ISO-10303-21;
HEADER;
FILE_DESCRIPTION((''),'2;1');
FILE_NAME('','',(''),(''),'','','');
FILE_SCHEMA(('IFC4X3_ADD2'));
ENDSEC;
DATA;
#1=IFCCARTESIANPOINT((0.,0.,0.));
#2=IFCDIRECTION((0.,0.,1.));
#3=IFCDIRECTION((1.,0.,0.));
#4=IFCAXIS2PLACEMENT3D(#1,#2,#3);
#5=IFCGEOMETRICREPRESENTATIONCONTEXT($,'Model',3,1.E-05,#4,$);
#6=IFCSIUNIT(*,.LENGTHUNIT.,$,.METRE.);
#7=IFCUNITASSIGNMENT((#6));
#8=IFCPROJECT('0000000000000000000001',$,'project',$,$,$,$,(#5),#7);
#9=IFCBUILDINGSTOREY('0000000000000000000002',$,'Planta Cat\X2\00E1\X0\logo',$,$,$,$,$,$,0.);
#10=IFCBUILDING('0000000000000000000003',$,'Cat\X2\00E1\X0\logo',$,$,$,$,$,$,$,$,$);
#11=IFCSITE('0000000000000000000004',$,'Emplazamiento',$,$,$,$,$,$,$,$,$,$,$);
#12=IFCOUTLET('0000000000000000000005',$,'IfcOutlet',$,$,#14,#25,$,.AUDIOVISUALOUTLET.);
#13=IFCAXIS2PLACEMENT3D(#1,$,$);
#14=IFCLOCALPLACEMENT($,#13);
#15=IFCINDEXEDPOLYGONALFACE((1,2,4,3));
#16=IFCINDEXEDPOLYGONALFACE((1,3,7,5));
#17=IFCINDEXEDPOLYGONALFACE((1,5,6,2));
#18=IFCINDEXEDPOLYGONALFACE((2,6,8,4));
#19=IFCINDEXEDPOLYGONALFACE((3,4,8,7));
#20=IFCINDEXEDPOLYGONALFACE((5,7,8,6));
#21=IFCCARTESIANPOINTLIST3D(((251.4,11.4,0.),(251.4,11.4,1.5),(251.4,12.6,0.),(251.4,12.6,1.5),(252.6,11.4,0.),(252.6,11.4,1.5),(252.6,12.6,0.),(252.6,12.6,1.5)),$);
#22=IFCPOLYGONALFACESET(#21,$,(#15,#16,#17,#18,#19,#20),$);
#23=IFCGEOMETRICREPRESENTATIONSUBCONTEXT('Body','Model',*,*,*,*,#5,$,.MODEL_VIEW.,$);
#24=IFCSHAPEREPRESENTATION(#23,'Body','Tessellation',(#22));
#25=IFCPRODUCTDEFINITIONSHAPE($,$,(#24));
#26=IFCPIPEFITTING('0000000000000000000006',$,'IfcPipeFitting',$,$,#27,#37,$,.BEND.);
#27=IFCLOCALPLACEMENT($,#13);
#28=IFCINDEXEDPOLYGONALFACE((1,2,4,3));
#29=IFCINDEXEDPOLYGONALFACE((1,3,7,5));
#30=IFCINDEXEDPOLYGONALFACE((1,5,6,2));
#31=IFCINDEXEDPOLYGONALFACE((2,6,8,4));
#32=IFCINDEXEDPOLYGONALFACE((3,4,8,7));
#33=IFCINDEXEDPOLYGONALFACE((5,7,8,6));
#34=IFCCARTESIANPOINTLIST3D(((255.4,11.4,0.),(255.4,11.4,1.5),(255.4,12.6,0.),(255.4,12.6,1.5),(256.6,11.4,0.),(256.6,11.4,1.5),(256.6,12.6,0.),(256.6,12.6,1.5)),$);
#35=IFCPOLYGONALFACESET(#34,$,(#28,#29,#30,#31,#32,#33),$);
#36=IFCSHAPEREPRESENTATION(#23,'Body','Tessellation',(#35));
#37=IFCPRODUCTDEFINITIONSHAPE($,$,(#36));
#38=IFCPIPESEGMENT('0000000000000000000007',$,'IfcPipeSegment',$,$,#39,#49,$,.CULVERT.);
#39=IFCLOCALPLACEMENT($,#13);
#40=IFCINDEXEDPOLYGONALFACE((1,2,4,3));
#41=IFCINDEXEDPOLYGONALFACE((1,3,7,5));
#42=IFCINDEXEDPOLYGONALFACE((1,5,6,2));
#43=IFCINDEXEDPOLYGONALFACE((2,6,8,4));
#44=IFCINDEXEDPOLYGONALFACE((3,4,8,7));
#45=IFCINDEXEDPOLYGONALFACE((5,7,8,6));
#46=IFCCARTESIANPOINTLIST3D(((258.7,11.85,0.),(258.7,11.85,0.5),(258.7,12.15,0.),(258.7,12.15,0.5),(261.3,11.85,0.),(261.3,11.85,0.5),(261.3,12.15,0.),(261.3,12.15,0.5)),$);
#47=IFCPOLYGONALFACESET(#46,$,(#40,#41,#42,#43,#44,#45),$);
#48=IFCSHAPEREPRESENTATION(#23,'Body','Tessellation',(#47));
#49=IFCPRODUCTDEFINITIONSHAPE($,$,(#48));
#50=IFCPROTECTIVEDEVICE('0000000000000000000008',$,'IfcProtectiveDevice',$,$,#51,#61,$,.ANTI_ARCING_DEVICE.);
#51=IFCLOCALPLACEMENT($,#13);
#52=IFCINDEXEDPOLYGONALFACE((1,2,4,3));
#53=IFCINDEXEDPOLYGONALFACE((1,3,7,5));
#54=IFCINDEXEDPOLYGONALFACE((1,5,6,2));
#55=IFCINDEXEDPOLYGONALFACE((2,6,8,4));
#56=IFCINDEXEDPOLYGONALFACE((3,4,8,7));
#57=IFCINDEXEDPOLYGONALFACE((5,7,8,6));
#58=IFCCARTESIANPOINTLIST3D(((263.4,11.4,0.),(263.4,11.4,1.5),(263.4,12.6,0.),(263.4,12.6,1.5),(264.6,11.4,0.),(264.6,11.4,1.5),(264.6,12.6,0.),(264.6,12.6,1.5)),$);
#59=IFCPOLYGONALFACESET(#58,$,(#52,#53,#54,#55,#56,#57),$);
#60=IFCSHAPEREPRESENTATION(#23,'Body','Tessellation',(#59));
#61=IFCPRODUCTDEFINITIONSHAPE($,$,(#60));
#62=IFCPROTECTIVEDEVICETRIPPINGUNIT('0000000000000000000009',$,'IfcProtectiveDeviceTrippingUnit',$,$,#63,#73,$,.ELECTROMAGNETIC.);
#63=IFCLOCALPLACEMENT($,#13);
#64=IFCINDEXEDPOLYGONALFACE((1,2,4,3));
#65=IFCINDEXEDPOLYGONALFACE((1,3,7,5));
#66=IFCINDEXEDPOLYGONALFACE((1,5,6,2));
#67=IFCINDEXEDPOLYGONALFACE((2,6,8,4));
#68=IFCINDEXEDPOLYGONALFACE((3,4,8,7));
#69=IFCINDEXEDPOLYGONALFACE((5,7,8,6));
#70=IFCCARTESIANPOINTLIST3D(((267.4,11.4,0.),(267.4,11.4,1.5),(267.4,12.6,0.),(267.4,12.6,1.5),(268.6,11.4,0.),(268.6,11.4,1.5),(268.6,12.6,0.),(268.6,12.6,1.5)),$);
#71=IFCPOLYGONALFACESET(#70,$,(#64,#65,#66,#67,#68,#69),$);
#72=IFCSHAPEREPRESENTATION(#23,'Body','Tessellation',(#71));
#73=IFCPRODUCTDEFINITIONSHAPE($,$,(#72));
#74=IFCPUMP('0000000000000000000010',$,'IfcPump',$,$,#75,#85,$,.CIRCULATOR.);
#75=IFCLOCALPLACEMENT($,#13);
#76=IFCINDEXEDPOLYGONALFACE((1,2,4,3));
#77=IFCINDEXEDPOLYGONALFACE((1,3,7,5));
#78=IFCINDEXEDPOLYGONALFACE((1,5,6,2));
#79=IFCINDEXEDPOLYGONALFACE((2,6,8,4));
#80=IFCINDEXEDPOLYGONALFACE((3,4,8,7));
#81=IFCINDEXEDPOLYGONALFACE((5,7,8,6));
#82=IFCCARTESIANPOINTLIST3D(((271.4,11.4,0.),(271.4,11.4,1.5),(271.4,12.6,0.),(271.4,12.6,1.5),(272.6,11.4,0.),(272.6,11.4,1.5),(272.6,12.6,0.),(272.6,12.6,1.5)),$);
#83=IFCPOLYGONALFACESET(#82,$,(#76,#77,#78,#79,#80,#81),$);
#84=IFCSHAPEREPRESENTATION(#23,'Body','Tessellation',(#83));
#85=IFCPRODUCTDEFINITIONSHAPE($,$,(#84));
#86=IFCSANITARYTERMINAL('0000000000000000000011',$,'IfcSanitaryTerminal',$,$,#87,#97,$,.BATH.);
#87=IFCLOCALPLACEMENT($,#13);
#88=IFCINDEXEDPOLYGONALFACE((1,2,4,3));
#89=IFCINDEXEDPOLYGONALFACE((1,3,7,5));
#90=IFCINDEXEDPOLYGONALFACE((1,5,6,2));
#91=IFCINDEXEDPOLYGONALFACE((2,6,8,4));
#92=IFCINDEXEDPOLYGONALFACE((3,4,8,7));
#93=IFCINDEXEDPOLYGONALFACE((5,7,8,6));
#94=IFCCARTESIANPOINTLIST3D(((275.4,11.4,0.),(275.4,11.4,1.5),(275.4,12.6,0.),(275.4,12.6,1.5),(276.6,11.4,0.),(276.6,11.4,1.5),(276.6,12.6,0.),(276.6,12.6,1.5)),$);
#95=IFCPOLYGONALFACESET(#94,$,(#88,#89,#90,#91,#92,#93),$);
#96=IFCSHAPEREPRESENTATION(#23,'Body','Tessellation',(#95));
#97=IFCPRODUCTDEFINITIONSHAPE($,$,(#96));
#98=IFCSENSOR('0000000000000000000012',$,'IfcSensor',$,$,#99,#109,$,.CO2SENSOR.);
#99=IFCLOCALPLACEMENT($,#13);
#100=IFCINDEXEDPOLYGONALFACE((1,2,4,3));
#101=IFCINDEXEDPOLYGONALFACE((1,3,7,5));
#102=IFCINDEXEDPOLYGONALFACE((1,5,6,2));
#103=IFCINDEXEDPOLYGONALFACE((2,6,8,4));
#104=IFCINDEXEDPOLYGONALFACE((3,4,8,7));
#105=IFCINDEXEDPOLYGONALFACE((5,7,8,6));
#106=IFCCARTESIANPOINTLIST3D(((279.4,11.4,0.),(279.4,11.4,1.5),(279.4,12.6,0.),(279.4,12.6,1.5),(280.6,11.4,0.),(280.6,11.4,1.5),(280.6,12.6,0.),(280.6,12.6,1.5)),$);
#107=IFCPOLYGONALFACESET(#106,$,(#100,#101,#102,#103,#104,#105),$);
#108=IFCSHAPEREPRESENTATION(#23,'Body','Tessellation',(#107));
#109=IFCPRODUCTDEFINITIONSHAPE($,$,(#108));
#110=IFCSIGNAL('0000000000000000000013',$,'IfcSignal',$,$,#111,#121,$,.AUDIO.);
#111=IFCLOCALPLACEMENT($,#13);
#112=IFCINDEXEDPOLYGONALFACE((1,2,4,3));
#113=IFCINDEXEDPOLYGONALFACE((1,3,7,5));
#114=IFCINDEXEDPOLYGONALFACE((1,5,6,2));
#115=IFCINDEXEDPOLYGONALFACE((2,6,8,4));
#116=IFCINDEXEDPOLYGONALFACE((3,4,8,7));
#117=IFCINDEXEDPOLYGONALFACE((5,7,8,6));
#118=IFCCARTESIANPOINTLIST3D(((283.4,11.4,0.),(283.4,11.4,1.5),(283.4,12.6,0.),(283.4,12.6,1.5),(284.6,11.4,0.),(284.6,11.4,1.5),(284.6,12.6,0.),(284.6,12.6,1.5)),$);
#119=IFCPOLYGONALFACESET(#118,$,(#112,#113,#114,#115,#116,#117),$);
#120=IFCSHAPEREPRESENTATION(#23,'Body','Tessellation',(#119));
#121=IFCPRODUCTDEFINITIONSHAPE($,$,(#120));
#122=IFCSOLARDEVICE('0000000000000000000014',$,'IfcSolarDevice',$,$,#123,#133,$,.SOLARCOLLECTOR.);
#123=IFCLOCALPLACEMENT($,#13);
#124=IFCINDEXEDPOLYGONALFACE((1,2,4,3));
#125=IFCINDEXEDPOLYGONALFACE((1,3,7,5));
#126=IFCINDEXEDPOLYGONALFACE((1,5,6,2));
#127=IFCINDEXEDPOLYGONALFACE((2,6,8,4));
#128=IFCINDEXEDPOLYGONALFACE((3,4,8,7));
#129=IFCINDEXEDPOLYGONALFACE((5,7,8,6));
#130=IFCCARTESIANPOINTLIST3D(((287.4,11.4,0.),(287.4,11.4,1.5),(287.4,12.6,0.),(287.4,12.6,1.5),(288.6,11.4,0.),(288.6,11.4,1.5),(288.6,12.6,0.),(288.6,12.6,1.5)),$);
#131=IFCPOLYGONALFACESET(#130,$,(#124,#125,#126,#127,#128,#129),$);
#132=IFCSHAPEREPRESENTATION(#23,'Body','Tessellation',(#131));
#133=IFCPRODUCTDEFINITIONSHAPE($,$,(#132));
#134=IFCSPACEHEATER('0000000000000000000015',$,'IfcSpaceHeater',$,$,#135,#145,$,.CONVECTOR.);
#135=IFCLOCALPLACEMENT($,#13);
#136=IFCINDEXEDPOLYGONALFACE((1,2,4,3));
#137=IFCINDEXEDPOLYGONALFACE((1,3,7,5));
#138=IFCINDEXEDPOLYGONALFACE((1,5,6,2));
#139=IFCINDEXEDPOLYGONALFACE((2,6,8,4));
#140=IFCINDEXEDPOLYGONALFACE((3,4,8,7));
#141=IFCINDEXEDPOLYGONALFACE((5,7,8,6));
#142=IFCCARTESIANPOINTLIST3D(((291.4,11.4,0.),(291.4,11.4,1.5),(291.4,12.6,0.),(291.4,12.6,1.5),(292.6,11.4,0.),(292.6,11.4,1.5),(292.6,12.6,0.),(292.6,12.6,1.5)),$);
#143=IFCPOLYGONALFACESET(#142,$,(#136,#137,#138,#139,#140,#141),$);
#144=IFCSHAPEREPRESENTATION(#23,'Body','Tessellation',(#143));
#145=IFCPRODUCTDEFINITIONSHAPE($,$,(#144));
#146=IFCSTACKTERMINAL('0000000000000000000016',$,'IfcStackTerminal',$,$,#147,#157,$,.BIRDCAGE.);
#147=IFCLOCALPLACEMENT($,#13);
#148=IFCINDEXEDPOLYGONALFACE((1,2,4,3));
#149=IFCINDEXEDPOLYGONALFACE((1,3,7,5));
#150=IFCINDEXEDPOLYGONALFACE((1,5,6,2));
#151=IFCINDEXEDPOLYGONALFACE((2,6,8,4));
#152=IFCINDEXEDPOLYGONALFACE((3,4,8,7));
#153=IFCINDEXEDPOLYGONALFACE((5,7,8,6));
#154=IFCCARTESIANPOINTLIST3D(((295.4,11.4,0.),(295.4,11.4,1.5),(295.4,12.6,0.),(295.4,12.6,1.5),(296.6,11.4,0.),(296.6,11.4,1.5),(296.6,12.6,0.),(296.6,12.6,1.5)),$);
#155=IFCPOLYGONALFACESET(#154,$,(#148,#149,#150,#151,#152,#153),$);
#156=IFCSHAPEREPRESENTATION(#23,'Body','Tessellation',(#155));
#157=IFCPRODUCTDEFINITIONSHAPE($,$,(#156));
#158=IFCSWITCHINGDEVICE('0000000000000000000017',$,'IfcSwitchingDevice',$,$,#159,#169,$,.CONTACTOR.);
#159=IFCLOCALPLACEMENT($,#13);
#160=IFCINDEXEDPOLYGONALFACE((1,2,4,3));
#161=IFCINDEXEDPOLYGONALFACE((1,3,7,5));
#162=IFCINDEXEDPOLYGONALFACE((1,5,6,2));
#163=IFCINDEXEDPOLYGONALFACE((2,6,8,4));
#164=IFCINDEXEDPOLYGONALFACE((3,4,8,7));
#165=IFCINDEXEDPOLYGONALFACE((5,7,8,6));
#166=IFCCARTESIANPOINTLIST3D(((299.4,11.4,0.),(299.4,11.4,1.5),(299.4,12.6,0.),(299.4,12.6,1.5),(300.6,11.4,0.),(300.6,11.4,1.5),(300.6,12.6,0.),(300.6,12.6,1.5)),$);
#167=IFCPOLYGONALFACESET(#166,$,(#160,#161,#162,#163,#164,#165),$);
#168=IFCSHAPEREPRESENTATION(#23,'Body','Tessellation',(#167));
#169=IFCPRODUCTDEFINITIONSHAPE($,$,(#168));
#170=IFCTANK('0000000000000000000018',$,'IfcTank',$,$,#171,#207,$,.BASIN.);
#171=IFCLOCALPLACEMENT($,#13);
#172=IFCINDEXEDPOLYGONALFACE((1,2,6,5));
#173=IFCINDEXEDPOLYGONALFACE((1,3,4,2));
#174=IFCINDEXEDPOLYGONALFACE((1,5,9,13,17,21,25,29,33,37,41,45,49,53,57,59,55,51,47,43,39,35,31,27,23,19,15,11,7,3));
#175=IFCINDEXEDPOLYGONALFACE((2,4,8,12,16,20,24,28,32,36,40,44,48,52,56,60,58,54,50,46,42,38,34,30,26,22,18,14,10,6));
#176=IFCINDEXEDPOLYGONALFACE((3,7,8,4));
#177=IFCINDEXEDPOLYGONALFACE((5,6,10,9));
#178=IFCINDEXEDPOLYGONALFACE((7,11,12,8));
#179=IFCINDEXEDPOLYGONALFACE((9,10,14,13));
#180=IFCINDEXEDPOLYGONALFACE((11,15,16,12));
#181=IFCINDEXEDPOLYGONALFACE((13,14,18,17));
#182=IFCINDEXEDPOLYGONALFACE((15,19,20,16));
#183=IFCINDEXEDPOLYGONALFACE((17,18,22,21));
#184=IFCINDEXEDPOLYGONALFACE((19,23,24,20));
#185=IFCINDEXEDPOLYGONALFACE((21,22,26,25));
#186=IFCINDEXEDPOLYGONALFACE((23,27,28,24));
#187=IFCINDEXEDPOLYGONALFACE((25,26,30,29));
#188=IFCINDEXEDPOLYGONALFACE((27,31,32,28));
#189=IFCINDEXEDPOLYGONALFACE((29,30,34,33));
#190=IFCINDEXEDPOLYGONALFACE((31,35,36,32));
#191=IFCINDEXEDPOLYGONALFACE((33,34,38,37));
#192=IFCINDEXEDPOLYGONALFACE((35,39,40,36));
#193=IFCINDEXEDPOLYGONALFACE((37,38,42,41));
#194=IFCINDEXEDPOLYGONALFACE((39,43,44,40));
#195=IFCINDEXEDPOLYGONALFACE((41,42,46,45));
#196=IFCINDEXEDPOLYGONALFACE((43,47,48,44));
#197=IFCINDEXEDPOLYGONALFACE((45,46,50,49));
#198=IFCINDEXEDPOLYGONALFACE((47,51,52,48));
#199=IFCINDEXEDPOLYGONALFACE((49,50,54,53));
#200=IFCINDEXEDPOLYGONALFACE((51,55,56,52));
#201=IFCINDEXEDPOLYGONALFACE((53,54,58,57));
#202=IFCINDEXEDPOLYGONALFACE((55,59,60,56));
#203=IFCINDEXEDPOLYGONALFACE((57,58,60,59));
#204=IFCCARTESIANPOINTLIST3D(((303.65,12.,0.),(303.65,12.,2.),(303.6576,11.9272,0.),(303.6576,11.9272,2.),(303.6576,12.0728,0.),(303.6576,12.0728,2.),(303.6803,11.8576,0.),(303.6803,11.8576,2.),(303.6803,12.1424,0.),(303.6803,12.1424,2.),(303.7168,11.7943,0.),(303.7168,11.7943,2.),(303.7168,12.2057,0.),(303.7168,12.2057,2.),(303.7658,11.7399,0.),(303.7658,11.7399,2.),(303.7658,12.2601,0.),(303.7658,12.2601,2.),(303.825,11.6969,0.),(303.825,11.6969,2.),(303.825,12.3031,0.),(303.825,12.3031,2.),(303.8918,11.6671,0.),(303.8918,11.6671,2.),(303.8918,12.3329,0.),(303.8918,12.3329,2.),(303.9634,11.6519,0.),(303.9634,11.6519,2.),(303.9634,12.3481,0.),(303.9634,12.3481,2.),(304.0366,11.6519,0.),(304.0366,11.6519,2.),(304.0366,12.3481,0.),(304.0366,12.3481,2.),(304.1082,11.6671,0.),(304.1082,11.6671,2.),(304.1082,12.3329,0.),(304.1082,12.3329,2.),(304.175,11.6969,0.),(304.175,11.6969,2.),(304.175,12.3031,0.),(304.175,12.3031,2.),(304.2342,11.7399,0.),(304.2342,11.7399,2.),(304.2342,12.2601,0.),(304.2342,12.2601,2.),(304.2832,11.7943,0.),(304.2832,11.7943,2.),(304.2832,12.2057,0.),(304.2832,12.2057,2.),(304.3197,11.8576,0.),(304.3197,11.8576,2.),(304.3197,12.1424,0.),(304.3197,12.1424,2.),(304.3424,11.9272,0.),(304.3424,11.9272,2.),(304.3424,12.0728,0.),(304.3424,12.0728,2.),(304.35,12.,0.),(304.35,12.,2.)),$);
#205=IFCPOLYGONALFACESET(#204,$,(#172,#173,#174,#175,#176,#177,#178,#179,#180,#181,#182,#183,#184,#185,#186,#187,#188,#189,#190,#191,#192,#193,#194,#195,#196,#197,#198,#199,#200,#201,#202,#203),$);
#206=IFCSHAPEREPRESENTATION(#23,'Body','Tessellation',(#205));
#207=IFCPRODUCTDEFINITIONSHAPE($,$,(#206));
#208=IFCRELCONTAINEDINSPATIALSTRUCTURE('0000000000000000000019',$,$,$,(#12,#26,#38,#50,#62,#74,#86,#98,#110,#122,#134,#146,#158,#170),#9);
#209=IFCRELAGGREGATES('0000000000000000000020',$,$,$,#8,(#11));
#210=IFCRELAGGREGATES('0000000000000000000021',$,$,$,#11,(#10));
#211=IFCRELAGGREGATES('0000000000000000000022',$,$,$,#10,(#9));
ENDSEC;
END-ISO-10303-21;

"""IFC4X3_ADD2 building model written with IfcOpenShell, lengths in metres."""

from ifc_helpers import new_model, si_unit, frame, origin, origin_with_axes, origin_2d, place, context, subcontext, project, spatial, rectangle, circle, extrude, element, save


model = new_model("IFC4X3_ADD2")

# Units and contexts
model_context = context("Model", 3, precision=1e-05, world=origin_with_axes())
body_context = subcontext(model_context, "Body", "Model", "MODEL_VIEW")
ifc_project = project(units=[si_unit("LENGTHUNIT", "METRE")], contexts=[model_context])

# Site, building, storey
site = spatial("IfcSite", under=ifc_project, Name="Emplazamiento")
building = spatial("IfcBuilding", under=site, Name="Catálogo")
storey = spatial("IfcBuildingStorey", under=building, Name="Planta Catálogo", Elevation=0.0)

# Outlet
outlet_placement = place(None, frame((252.0, 12.0, 0.0), z_axis=(0.0, 0.0, 1.0), x_axis=(1.0, 0.0, 0.0)))
element("IfcOutlet", 1, at=outlet_placement, inside=storey, Name="IfcOutlet", PredefinedType="AUDIOVISUALOUTLET", context=body_context, shape_type="SweptSolid", body=[
    extrude(rectangle(XDim=1.2, YDim=1.2, at=origin_2d()), origin(), (0.0, 0.0, 1.0), 1.5),
])

# Pipe fitting
pipe_fitting_placement = place(None, frame((256.0, 12.0, 0.0), z_axis=(0.0, 0.0, 1.0), x_axis=(1.0, 0.0, 0.0)))
element("IfcPipeFitting", 2, at=pipe_fitting_placement, inside=storey, Name="IfcPipeFitting", PredefinedType="BEND", context=body_context, shape_type="SweptSolid", body=[
    extrude(rectangle(XDim=1.2, YDim=1.2, at=origin_2d()), origin(), (0.0, 0.0, 1.0), 1.5),
])

# Pipe segment
pipe_segment_placement = place(None, frame((260.0, 12.0, 0.0), z_axis=(0.0, 0.0, 1.0), x_axis=(1.0, 0.0, 0.0)))
element("IfcPipeSegment", 3, at=pipe_segment_placement, inside=storey, Name="IfcPipeSegment", PredefinedType="CULVERT", context=body_context, shape_type="SweptSolid", body=[
    extrude(rectangle(XDim=2.6, YDim=0.3, at=origin_2d()), origin(), (0.0, 0.0, 1.0), 0.5),
])

# Protective device
protective_device_placement = place(None, frame((264.0, 12.0, 0.0), z_axis=(0.0, 0.0, 1.0), x_axis=(1.0, 0.0, 0.0)))
element("IfcProtectiveDevice", 4, at=protective_device_placement, inside=storey, Name="IfcProtectiveDevice", PredefinedType="ANTI_ARCING_DEVICE", context=body_context, shape_type="SweptSolid", body=[
    extrude(rectangle(XDim=1.2, YDim=1.2, at=origin_2d()), origin(), (0.0, 0.0, 1.0), 1.5),
])

# Protective device tripping unit
protective_device_tripping_unit_placement = place(None, frame((268.0, 12.0, 0.0), z_axis=(0.0, 0.0, 1.0), x_axis=(1.0, 0.0, 0.0)))
element("IfcProtectiveDeviceTrippingUnit", 5, at=protective_device_tripping_unit_placement, inside=storey, Name="IfcProtectiveDeviceTrippingUnit", PredefinedType="ELECTROMAGNETIC", context=body_context, shape_type="SweptSolid", body=[
    extrude(rectangle(XDim=1.2, YDim=1.2, at=origin_2d()), origin(), (0.0, 0.0, 1.0), 1.5),
])

# Pump
pump_placement = place(None, frame((272.0, 12.0, 0.0), z_axis=(0.0, 0.0, 1.0), x_axis=(1.0, 0.0, 0.0)))
element("IfcPump", 6, at=pump_placement, inside=storey, Name="IfcPump", PredefinedType="CIRCULATOR", context=body_context, shape_type="SweptSolid", body=[
    extrude(rectangle(XDim=1.2, YDim=1.2, at=origin_2d()), origin(), (0.0, 0.0, 1.0), 1.5),
])

# Sanitary terminal
sanitary_terminal_placement = place(None, frame((276.0, 12.0, 0.0), z_axis=(0.0, 0.0, 1.0), x_axis=(1.0, 0.0, 0.0)))
element("IfcSanitaryTerminal", 7, at=sanitary_terminal_placement, inside=storey, Name="IfcSanitaryTerminal", PredefinedType="BATH", context=body_context, shape_type="SweptSolid", body=[
    extrude(rectangle(XDim=1.2, YDim=1.2, at=origin_2d()), origin(), (0.0, 0.0, 1.0), 1.5),
])

# Sensor
sensor_placement = place(None, frame((280.0, 12.0, 0.0), z_axis=(0.0, 0.0, 1.0), x_axis=(1.0, 0.0, 0.0)))
element("IfcSensor", 8, at=sensor_placement, inside=storey, Name="IfcSensor", PredefinedType="CO2SENSOR", context=body_context, shape_type="SweptSolid", body=[
    extrude(rectangle(XDim=1.2, YDim=1.2, at=origin_2d()), origin(), (0.0, 0.0, 1.0), 1.5),
])

# Signal
signal_placement = place(None, frame((284.0, 12.0, 0.0), z_axis=(0.0, 0.0, 1.0), x_axis=(1.0, 0.0, 0.0)))
element("IfcSignal", 9, at=signal_placement, inside=storey, Name="IfcSignal", PredefinedType="AUDIO", context=body_context, shape_type="SweptSolid", body=[
    extrude(rectangle(XDim=1.2, YDim=1.2, at=origin_2d()), origin(), (0.0, 0.0, 1.0), 1.5),
])

# Solar device
solar_device_placement = place(None, frame((288.0, 12.0, 0.0), z_axis=(0.0, 0.0, 1.0), x_axis=(1.0, 0.0, 0.0)))
element("IfcSolarDevice", 10, at=solar_device_placement, inside=storey, Name="IfcSolarDevice", PredefinedType="SOLARCOLLECTOR", context=body_context, shape_type="SweptSolid", body=[
    extrude(rectangle(XDim=1.2, YDim=1.2, at=origin_2d()), origin(), (0.0, 0.0, 1.0), 1.5),
])

# Space heater
space_heater_placement = place(None, frame((292.0, 12.0, 0.0), z_axis=(0.0, 0.0, 1.0), x_axis=(1.0, 0.0, 0.0)))
element("IfcSpaceHeater", 11, at=space_heater_placement, inside=storey, Name="IfcSpaceHeater", PredefinedType="CONVECTOR", context=body_context, shape_type="SweptSolid", body=[
    extrude(rectangle(XDim=1.2, YDim=1.2, at=origin_2d()), origin(), (0.0, 0.0, 1.0), 1.5),
])

# Stack terminal
stack_terminal_placement = place(None, frame((296.0, 12.0, 0.0), z_axis=(0.0, 0.0, 1.0), x_axis=(1.0, 0.0, 0.0)))
element("IfcStackTerminal", 12, at=stack_terminal_placement, inside=storey, Name="IfcStackTerminal", PredefinedType="BIRDCAGE", context=body_context, shape_type="SweptSolid", body=[
    extrude(rectangle(XDim=1.2, YDim=1.2, at=origin_2d()), origin(), (0.0, 0.0, 1.0), 1.5),
])

# Switching device
switching_device_placement = place(None, frame((300.0, 12.0, 0.0), z_axis=(0.0, 0.0, 1.0), x_axis=(1.0, 0.0, 0.0)))
element("IfcSwitchingDevice", 13, at=switching_device_placement, inside=storey, Name="IfcSwitchingDevice", PredefinedType="CONTACTOR", context=body_context, shape_type="SweptSolid", body=[
    extrude(rectangle(XDim=1.2, YDim=1.2, at=origin_2d()), origin(), (0.0, 0.0, 1.0), 1.5),
])

# Tank
tank_placement = place(None, frame((304.0, 12.0, 0.0), z_axis=(0.0, 0.0, 1.0), x_axis=(1.0, 0.0, 0.0)))
element("IfcTank", 14, at=tank_placement, inside=storey, Name="IfcTank", PredefinedType="BASIN", context=body_context, shape_type="SweptSolid", body=[
    extrude(circle(Radius=0.35, at=origin_2d()), origin(), (0.0, 0.0, 1.0), 2.0),
])

save(model, "model.ifc")
